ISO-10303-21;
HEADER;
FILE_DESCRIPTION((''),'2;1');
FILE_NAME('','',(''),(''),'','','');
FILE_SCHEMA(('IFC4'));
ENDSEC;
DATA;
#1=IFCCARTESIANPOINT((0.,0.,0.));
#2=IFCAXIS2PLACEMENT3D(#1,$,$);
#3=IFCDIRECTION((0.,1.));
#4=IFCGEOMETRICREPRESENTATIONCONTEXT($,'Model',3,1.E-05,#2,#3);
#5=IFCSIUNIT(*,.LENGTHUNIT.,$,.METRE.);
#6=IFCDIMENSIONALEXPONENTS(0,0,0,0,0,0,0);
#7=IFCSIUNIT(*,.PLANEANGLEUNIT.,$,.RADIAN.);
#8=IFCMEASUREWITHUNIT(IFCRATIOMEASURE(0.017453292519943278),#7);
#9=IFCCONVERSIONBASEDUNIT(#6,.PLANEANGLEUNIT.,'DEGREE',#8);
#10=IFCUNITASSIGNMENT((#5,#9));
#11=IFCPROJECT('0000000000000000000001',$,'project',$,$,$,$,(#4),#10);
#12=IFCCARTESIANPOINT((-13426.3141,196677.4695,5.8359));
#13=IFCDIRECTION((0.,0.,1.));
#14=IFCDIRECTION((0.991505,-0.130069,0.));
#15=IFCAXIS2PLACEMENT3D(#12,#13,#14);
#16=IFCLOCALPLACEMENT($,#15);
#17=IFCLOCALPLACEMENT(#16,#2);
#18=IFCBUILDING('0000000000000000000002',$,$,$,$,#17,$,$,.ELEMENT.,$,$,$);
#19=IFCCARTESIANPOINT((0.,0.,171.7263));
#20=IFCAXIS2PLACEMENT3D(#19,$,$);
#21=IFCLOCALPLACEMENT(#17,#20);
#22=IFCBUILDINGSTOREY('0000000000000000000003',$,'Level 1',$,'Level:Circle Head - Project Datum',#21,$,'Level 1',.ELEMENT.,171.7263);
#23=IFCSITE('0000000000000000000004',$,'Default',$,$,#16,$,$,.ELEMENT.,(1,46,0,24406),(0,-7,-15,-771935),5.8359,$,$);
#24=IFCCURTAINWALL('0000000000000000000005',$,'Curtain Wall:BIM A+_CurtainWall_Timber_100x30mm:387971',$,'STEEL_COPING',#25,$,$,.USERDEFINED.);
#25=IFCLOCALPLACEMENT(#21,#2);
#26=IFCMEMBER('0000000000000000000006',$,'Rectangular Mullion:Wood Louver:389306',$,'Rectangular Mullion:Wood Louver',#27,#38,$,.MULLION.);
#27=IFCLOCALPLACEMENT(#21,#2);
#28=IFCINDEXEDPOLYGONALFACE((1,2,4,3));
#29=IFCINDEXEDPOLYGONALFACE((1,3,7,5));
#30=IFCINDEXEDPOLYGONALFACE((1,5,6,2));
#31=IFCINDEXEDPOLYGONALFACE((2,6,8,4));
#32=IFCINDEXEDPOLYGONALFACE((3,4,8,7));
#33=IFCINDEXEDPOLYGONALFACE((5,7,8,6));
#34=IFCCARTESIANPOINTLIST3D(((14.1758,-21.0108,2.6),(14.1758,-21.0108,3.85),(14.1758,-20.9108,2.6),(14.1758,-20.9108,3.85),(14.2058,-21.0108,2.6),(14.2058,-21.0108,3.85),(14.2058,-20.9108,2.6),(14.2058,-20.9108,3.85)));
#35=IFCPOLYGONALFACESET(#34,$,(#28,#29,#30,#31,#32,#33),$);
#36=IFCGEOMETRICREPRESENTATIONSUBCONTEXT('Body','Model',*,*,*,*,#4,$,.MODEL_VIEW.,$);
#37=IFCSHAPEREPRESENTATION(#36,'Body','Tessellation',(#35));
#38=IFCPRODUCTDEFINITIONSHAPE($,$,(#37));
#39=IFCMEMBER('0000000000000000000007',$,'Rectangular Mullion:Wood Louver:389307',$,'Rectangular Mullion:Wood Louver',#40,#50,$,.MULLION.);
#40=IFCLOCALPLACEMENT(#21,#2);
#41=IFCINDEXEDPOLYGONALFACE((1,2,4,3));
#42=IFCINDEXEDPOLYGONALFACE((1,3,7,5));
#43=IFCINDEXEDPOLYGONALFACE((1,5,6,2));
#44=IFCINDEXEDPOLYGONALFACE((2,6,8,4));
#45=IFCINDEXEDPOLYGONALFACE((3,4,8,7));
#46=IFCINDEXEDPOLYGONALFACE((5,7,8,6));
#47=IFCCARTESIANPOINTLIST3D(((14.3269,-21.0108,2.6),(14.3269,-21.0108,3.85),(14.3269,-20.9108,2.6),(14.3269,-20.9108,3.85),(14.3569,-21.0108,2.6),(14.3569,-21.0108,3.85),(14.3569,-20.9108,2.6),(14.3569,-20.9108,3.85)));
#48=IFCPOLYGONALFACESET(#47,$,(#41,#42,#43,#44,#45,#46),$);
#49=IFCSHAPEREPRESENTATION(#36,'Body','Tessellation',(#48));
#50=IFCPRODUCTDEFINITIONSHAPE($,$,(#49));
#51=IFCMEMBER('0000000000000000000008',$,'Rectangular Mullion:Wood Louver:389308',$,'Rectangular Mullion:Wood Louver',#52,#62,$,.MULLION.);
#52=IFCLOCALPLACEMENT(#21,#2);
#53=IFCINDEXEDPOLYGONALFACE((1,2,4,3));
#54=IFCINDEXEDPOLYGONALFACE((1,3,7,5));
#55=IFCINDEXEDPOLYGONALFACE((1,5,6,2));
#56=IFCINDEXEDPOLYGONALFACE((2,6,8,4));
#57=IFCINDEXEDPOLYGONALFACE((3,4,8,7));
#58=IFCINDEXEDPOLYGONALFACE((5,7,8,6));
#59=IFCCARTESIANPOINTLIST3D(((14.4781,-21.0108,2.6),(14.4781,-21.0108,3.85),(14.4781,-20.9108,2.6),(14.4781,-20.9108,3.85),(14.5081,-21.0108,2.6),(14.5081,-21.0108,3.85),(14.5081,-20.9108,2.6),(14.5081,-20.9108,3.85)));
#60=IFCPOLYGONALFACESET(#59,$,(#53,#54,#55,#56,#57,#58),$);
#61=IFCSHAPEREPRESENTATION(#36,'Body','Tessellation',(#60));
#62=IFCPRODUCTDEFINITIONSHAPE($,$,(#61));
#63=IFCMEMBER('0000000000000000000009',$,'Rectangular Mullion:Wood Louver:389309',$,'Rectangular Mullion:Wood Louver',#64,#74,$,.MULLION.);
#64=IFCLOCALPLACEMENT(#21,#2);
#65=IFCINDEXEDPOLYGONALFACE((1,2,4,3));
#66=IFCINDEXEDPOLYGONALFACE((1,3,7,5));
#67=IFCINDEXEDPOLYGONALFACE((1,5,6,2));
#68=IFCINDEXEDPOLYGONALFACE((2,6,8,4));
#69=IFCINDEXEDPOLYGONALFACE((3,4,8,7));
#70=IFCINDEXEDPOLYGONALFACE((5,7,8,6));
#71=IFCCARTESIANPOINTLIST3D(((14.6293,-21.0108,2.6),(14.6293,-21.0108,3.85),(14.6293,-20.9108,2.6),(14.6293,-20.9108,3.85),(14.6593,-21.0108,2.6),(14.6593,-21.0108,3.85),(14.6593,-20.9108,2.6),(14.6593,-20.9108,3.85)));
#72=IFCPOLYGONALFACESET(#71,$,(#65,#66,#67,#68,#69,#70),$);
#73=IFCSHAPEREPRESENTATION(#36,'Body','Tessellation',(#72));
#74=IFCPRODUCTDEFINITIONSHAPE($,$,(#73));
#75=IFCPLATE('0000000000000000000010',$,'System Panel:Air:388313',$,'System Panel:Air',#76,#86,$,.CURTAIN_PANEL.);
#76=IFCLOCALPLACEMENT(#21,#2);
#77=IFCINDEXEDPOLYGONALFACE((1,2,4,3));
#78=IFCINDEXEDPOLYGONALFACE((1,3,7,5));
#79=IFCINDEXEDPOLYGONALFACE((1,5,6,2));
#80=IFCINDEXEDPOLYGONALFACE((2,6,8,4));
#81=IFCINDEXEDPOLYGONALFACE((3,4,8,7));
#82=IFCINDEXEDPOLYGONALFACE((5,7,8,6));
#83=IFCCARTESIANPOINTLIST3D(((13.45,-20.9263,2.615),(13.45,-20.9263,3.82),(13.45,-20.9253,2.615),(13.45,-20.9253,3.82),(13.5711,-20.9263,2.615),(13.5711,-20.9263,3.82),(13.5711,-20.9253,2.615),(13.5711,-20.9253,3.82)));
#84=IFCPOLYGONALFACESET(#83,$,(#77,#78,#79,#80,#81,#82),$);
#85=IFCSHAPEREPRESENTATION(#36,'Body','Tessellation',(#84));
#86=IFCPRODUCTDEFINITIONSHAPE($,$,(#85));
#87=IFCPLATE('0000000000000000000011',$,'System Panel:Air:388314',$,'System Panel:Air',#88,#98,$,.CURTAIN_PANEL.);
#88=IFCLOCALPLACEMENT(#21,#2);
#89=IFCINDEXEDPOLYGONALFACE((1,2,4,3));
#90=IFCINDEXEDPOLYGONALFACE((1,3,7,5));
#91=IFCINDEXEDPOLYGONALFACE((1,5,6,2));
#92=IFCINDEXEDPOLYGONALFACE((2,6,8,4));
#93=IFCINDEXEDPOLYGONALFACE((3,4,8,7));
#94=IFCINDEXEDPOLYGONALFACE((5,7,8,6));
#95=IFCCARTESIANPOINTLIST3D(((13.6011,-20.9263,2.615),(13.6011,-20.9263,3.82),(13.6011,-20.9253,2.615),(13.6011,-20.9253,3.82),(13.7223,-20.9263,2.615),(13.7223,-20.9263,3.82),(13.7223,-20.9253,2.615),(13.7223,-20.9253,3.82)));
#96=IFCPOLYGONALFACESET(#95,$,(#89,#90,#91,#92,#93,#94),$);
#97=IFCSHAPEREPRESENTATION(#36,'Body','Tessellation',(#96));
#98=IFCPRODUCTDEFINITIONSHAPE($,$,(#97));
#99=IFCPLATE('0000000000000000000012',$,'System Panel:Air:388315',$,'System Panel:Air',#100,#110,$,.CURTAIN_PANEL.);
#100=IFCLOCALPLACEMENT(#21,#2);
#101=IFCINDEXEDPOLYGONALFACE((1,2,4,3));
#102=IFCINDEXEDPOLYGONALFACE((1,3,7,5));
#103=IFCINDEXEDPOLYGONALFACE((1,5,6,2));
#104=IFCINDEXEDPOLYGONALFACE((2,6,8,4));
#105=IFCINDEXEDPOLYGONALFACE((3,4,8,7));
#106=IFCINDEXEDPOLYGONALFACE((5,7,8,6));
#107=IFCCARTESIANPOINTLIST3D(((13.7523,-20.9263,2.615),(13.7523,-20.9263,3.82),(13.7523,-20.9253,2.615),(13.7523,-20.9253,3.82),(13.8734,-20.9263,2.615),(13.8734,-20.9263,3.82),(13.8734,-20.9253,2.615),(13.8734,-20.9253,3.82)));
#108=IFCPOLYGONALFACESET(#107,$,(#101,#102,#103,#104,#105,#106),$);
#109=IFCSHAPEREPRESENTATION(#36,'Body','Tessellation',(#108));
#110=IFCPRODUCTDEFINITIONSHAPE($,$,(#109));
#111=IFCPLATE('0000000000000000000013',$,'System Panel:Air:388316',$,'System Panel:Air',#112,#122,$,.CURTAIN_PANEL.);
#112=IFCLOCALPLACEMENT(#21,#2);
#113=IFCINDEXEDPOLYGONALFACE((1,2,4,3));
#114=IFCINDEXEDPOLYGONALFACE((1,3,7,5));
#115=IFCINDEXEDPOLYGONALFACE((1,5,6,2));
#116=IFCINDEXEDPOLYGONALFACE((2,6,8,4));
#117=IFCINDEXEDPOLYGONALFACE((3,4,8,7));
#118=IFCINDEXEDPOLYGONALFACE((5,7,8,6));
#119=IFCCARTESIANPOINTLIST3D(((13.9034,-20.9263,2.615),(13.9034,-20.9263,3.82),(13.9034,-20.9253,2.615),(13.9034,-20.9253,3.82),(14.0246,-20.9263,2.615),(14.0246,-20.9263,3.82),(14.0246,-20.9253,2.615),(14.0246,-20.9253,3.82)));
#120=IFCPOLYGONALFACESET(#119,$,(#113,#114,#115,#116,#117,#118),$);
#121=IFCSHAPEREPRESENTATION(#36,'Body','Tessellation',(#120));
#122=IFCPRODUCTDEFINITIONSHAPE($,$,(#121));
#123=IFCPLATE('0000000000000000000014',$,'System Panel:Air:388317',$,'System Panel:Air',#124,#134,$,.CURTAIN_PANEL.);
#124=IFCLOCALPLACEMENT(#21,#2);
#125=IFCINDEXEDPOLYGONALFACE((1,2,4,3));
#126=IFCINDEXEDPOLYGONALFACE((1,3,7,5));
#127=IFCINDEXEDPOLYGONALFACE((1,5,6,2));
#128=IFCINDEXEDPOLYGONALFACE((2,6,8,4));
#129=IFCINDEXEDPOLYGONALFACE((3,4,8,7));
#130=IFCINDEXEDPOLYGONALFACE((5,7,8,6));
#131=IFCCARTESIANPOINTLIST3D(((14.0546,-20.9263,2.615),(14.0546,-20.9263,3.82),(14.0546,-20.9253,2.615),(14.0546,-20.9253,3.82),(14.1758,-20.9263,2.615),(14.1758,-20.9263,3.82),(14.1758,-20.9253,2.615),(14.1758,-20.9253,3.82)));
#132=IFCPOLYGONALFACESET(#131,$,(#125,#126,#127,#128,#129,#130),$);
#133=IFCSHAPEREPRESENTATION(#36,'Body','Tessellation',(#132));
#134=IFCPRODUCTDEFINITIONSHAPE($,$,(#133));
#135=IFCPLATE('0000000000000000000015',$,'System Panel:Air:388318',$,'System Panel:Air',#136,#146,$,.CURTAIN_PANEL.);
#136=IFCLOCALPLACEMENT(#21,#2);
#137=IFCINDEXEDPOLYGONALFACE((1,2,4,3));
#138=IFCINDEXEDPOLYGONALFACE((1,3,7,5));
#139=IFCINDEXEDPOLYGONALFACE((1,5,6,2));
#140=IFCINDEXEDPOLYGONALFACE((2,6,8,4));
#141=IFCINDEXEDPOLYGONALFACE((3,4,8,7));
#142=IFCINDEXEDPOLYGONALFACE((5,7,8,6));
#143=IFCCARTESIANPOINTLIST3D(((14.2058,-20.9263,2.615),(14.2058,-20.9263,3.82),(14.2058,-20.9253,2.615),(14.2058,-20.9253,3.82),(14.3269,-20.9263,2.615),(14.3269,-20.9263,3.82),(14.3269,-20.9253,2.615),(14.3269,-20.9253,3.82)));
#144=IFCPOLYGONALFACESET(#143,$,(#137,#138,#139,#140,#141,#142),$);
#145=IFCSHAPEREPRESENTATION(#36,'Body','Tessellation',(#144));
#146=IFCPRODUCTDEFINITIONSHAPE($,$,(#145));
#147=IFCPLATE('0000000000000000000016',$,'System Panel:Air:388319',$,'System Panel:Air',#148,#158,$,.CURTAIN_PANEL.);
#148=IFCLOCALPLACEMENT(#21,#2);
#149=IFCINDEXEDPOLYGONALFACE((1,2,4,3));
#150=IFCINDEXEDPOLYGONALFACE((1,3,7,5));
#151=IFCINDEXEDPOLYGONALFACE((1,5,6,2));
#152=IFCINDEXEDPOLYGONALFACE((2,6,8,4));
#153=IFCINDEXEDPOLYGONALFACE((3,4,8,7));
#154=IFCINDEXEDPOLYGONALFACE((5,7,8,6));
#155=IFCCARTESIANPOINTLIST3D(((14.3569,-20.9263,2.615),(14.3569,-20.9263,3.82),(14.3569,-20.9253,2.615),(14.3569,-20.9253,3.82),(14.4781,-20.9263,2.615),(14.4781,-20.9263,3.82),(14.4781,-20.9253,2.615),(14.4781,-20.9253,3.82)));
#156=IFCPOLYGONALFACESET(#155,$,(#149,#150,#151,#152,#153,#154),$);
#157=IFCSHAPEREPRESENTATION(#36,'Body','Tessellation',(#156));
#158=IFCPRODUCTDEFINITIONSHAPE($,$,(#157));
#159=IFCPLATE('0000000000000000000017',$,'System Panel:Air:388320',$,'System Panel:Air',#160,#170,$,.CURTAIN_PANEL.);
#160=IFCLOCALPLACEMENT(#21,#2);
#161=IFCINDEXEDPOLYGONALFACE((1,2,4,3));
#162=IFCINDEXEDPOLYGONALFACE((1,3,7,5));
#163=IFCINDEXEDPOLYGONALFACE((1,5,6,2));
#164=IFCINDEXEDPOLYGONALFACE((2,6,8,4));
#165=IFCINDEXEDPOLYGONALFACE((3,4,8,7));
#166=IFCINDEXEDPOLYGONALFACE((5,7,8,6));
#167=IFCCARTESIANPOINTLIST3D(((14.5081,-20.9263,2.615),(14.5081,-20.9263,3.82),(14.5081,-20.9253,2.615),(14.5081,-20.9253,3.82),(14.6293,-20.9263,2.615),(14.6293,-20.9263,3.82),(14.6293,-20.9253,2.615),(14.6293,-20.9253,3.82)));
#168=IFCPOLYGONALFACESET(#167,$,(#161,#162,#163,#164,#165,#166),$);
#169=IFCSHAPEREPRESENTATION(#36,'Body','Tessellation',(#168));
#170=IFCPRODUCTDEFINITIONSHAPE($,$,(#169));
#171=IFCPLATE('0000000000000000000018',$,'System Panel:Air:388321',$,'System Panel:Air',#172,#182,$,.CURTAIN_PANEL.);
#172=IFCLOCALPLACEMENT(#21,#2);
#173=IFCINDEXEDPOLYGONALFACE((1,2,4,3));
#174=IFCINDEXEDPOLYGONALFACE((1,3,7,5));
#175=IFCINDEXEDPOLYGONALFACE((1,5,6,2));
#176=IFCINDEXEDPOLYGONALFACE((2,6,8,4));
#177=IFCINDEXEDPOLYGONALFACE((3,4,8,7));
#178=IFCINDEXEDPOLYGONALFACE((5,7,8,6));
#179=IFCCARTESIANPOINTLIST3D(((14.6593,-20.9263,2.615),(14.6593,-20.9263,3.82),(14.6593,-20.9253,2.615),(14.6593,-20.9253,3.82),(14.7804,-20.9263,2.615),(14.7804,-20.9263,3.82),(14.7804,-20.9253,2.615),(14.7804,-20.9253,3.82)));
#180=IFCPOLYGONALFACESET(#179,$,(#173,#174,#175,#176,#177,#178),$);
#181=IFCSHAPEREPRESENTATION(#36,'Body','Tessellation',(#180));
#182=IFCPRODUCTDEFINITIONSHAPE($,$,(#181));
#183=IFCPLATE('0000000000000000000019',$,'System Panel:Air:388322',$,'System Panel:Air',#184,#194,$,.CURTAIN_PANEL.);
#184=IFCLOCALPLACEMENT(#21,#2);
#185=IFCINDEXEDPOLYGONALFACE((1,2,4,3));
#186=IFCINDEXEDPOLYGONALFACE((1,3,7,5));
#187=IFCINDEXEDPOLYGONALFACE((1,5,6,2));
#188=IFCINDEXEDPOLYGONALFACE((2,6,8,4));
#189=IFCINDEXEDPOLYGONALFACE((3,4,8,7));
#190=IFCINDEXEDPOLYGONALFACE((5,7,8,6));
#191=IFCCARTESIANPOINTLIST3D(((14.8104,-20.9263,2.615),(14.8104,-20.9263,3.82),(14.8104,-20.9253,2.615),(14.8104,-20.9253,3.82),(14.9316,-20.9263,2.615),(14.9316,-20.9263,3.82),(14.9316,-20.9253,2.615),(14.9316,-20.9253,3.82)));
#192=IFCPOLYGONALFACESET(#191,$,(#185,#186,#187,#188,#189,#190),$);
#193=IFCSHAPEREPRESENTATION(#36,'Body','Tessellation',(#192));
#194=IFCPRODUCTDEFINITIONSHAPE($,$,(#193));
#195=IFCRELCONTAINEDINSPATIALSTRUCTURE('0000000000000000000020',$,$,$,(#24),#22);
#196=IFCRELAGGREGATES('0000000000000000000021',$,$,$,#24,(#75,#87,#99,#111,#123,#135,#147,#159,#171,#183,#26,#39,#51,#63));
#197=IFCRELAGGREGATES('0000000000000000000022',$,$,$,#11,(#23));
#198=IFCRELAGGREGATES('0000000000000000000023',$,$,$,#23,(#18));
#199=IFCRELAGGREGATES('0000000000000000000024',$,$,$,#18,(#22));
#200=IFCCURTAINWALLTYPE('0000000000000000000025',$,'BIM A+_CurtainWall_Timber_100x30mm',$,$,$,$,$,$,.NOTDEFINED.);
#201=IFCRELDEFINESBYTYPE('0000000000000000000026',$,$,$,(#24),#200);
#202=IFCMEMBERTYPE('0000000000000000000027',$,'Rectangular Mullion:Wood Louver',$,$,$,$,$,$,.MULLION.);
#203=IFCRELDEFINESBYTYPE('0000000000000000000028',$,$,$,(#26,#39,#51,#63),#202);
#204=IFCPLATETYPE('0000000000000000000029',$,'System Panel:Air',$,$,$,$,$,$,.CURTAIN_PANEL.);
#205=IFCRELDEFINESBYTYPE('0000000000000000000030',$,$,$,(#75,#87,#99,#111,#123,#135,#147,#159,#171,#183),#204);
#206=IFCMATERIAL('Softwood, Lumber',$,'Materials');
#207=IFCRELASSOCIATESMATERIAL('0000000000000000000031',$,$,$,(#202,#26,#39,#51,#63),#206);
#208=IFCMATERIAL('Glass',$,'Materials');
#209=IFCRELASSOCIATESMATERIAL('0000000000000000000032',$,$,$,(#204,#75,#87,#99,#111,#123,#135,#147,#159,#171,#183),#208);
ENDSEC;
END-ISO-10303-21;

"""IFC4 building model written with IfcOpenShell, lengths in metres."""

from ifc_helpers import new_model, entity, si_unit, converted_unit, direction, frame, origin, place, context, subcontext, project, spatial, indexed_curve, outline, extrude, source, transform, mapped, material, type_object, type_shapes, element, aggregate, save


model = new_model("IFC4")

# Units and contexts
model_context = context("Model", 3, precision=1e-05, world=origin(), true_north=direction((0.0, 1.0)))
body_context = subcontext(model_context, "Body", "Model", "MODEL_VIEW")
ifc_project = project(units=[si_unit("LENGTHUNIT", "METRE"), converted_unit("PLANEANGLEUNIT", "DEGREE", entity("IfcRatioMeasure", 0.017453292519943278), si_unit("PLANEANGLEUNIT", "RADIAN"), dimensions=[0, 0, 0, 0, 0, 0, 0])], contexts=[model_context])

# Site, building, storey
site_placement = place(None, frame((-13426.3141, 196677.4695, 5.8359), z_axis=(0.0, 0.0, 1.0), x_axis=(0.991505, -0.130069, 0.0)))
site = spatial("IfcSite", under=ifc_project, at=site_placement, Name="Default", CompositionType="ELEMENT", RefLatitude=(1, 46, 0, 24406), RefLongitude=(0, -7, -15, -771935), RefElevation=5.8359)
building_placement = place(site_placement, origin())
building = spatial("IfcBuilding", under=site, at=building_placement, CompositionType="ELEMENT")
storey_placement = place(building_placement, frame((0.0, 0.0, 171.7263)))
storey = spatial("IfcBuildingStorey", under=building, at=storey_placement, Name="Level 1", ObjectType="Level:Circle Head - Project Datum", LongName="Level 1", CompositionType="ELEMENT", Elevation=171.7263)

# Curtain wall, members, plates
curtain_wall_type = type_object("IfcCurtainWallType", Name="BIM A+_CurtainWall_Timber_100x30mm", PredefinedType="NOTDEFINED")
curtain_wall_placement = place(storey_placement, frame((0.0, 0.0, -171.7263)))
curtain_wall = element("IfcCurtainWall", 1, at=curtain_wall_placement, inside=storey, type_object=curtain_wall_type, Name="Curtain Wall:BIM A+_CurtainWall_Timber_100x30mm:387971", ObjectType="STEEL_COPING", PredefinedType="USERDEFINED")
ifc_material_1 = material(Name="Softwood, Lumber", Category="Materials")
member_type_1 = type_object("IfcMemberType", Name="Rectangular Mullion:Wood Louver", PredefinedType="MULLION", material=ifc_material_1)
shared_shape_1 = source(origin(), body_context, "Body", "SweptSolid", [
    extrude(outline(indexed_curve([(-0.05, -0.015), (0.05, -0.015), (0.05, 0.015), (-0.05, 0.015), (-0.05, -0.015)], self_intersect=False)), frame((0.0, 0.035, -1.25), z_axis=(0.0, 0.0, 1.0), x_axis=(0.0, -1.0, 0.0)), (0.0, 0.0, 1.0), 1.25),
])
type_shapes(member_type_1, [shared_shape_1])
member_1_placement = place(curtain_wall_placement, frame((14.1908, -20.9258, 174.3263), z_axis=(0.0, 0.0, -1.0), x_axis=(1.0, 0.0, 0.0)))
member_1 = element("IfcMember", 2, at=member_1_placement, type_object=member_type_1, material=ifc_material_1, Name="Rectangular Mullion:Wood Louver:389306", ObjectType="Rectangular Mullion:Wood Louver", PredefinedType="MULLION", context=body_context, shape_type="MappedRepresentation", body=[
    mapped(shared_shape_1, transform((0.0, 0.0, 0.0), scale=1.0)),
])
member_2_placement = place(curtain_wall_placement, frame((14.3419, -20.9258, 174.3263), z_axis=(0.0, 0.0, -1.0), x_axis=(1.0, 0.0, 0.0)))
member_2 = element("IfcMember", 3, at=member_2_placement, type_object=member_type_1, material=ifc_material_1, Name="Rectangular Mullion:Wood Louver:389307", ObjectType="Rectangular Mullion:Wood Louver", PredefinedType="MULLION", context=body_context, shape_type="MappedRepresentation", body=[
    mapped(shared_shape_1, transform((0.0, 0.0, 0.0), scale=1.0)),
])
member_3_placement = place(curtain_wall_placement, frame((14.4931, -20.9258, 174.3263), z_axis=(0.0, 0.0, -1.0), x_axis=(1.0, 0.0, 0.0)))
member_3 = element("IfcMember", 4, at=member_3_placement, type_object=member_type_1, material=ifc_material_1, Name="Rectangular Mullion:Wood Louver:389308", ObjectType="Rectangular Mullion:Wood Louver", PredefinedType="MULLION", context=body_context, shape_type="MappedRepresentation", body=[
    mapped(shared_shape_1, transform((0.0, 0.0, 0.0), scale=1.0)),
])
member_4_placement = place(curtain_wall_placement, frame((14.6443, -20.9258, 174.3263), z_axis=(0.0, 0.0, -1.0), x_axis=(1.0, 0.0, 0.0)))
member_4 = element("IfcMember", 5, at=member_4_placement, type_object=member_type_1, material=ifc_material_1, Name="Rectangular Mullion:Wood Louver:389309", ObjectType="Rectangular Mullion:Wood Louver", PredefinedType="MULLION", context=body_context, shape_type="MappedRepresentation", body=[
    mapped(shared_shape_1, transform((0.0, 0.0, 0.0), scale=1.0)),
])
ifc_material_2 = material(Name="Glass", Category="Materials")
plate_type = type_object("IfcPlateType", Name="System Panel:Air", PredefinedType="CURTAIN_PANEL", material=ifc_material_2)
shared_shape_2 = source(origin(), body_context, "Body", "SweptSolid", [
    extrude(outline(indexed_curve([(-0.0005, -0.0606), (0.0005, -0.0606), (0.0005, 0.0606), (-0.0005, 0.0606), (-0.0005, -0.0606)], self_intersect=False)), frame((0.0, 0.0, 0.0), z_axis=(0.0, 0.0, 1.0), x_axis=(0.0, 1.0, 0.0)), (0.0, 0.0, 1.0), 1.205),
])
type_shapes(plate_type, [shared_shape_2])
plate_1_placement = place(curtain_wall_placement, frame((13.5105, -20.9258, 174.3413)))
plate_1 = element("IfcPlate", 6, at=plate_1_placement, type_object=plate_type, material=ifc_material_2, Name="System Panel:Air:388313", ObjectType="System Panel:Air", PredefinedType="CURTAIN_PANEL", context=body_context, shape_type="MappedRepresentation", body=[
    mapped(shared_shape_2, transform((0.0, 0.0, 0.0), scale=1.0)),
])
plate_2_placement = place(curtain_wall_placement, frame((13.6617, -20.9258, 174.3413)))
plate_2 = element("IfcPlate", 7, at=plate_2_placement, type_object=plate_type, material=ifc_material_2, Name="System Panel:Air:388314", ObjectType="System Panel:Air", PredefinedType="CURTAIN_PANEL", context=body_context, shape_type="MappedRepresentation", body=[
    mapped(shared_shape_2, transform((0.0, 0.0, 0.0), scale=1.0)),
])
plate_3_placement = place(curtain_wall_placement, frame((13.8129, -20.9258, 174.3413)))
plate_3 = element("IfcPlate", 8, at=plate_3_placement, type_object=plate_type, material=ifc_material_2, Name="System Panel:Air:388315", ObjectType="System Panel:Air", PredefinedType="CURTAIN_PANEL", context=body_context, shape_type="MappedRepresentation", body=[
    mapped(shared_shape_2, transform((0.0, 0.0, 0.0), scale=1.0)),
])
plate_4_placement = place(curtain_wall_placement, frame((13.964, -20.9258, 174.3413)))
plate_4 = element("IfcPlate", 9, at=plate_4_placement, type_object=plate_type, material=ifc_material_2, Name="System Panel:Air:388316", ObjectType="System Panel:Air", PredefinedType="CURTAIN_PANEL", context=body_context, shape_type="MappedRepresentation", body=[
    mapped(shared_shape_2, transform((0.0, 0.0, 0.0), scale=1.0)),
])
plate_5_placement = place(curtain_wall_placement, frame((14.1152, -20.9258, 174.3413)))
plate_5 = element("IfcPlate", 10, at=plate_5_placement, type_object=plate_type, material=ifc_material_2, Name="System Panel:Air:388317", ObjectType="System Panel:Air", PredefinedType="CURTAIN_PANEL", context=body_context, shape_type="MappedRepresentation", body=[
    mapped(shared_shape_2, transform((0.0, 0.0, 0.0), scale=1.0)),
])
plate_6_placement = place(curtain_wall_placement, frame((14.2664, -20.9258, 174.3413)))
plate_6 = element("IfcPlate", 11, at=plate_6_placement, type_object=plate_type, material=ifc_material_2, Name="System Panel:Air:388318", ObjectType="System Panel:Air", PredefinedType="CURTAIN_PANEL", context=body_context, shape_type="MappedRepresentation", body=[
    mapped(shared_shape_2, transform((0.0, 0.0, 0.0), scale=1.0)),
])
plate_7_placement = place(curtain_wall_placement, frame((14.4175, -20.9258, 174.3413)))
plate_7 = element("IfcPlate", 12, at=plate_7_placement, type_object=plate_type, material=ifc_material_2, Name="System Panel:Air:388319", ObjectType="System Panel:Air", PredefinedType="CURTAIN_PANEL", context=body_context, shape_type="MappedRepresentation", body=[
    mapped(shared_shape_2, transform((0.0, 0.0, 0.0), scale=1.0)),
])
plate_8_placement = place(curtain_wall_placement, frame((14.5687, -20.9258, 174.3413)))
plate_8 = element("IfcPlate", 13, at=plate_8_placement, type_object=plate_type, material=ifc_material_2, Name="System Panel:Air:388320", ObjectType="System Panel:Air", PredefinedType="CURTAIN_PANEL", context=body_context, shape_type="MappedRepresentation", body=[
    mapped(shared_shape_2, transform((0.0, 0.0, 0.0), scale=1.0)),
])
plate_9_placement = place(curtain_wall_placement, frame((14.7198, -20.9258, 174.3413)))
plate_9 = element("IfcPlate", 14, at=plate_9_placement, type_object=plate_type, material=ifc_material_2, Name="System Panel:Air:388321", ObjectType="System Panel:Air", PredefinedType="CURTAIN_PANEL", context=body_context, shape_type="MappedRepresentation", body=[
    mapped(shared_shape_2, transform((0.0, 0.0, 0.0), scale=1.0)),
])
plate_10_placement = place(curtain_wall_placement, frame((14.871, -20.9258, 174.3413)))
plate_10 = element("IfcPlate", 15, at=plate_10_placement, type_object=plate_type, material=ifc_material_2, Name="System Panel:Air:388322", ObjectType="System Panel:Air", PredefinedType="CURTAIN_PANEL", context=body_context, shape_type="MappedRepresentation", body=[
    mapped(shared_shape_2, transform((0.0, 0.0, 0.0), scale=1.0)),
])
aggregate(curtain_wall, [plate_1, plate_2, plate_3, plate_4, plate_5, plate_6, plate_7, plate_8, plate_9, plate_10, member_1, member_2, member_3, member_4])

save(model, "model.ifc")
